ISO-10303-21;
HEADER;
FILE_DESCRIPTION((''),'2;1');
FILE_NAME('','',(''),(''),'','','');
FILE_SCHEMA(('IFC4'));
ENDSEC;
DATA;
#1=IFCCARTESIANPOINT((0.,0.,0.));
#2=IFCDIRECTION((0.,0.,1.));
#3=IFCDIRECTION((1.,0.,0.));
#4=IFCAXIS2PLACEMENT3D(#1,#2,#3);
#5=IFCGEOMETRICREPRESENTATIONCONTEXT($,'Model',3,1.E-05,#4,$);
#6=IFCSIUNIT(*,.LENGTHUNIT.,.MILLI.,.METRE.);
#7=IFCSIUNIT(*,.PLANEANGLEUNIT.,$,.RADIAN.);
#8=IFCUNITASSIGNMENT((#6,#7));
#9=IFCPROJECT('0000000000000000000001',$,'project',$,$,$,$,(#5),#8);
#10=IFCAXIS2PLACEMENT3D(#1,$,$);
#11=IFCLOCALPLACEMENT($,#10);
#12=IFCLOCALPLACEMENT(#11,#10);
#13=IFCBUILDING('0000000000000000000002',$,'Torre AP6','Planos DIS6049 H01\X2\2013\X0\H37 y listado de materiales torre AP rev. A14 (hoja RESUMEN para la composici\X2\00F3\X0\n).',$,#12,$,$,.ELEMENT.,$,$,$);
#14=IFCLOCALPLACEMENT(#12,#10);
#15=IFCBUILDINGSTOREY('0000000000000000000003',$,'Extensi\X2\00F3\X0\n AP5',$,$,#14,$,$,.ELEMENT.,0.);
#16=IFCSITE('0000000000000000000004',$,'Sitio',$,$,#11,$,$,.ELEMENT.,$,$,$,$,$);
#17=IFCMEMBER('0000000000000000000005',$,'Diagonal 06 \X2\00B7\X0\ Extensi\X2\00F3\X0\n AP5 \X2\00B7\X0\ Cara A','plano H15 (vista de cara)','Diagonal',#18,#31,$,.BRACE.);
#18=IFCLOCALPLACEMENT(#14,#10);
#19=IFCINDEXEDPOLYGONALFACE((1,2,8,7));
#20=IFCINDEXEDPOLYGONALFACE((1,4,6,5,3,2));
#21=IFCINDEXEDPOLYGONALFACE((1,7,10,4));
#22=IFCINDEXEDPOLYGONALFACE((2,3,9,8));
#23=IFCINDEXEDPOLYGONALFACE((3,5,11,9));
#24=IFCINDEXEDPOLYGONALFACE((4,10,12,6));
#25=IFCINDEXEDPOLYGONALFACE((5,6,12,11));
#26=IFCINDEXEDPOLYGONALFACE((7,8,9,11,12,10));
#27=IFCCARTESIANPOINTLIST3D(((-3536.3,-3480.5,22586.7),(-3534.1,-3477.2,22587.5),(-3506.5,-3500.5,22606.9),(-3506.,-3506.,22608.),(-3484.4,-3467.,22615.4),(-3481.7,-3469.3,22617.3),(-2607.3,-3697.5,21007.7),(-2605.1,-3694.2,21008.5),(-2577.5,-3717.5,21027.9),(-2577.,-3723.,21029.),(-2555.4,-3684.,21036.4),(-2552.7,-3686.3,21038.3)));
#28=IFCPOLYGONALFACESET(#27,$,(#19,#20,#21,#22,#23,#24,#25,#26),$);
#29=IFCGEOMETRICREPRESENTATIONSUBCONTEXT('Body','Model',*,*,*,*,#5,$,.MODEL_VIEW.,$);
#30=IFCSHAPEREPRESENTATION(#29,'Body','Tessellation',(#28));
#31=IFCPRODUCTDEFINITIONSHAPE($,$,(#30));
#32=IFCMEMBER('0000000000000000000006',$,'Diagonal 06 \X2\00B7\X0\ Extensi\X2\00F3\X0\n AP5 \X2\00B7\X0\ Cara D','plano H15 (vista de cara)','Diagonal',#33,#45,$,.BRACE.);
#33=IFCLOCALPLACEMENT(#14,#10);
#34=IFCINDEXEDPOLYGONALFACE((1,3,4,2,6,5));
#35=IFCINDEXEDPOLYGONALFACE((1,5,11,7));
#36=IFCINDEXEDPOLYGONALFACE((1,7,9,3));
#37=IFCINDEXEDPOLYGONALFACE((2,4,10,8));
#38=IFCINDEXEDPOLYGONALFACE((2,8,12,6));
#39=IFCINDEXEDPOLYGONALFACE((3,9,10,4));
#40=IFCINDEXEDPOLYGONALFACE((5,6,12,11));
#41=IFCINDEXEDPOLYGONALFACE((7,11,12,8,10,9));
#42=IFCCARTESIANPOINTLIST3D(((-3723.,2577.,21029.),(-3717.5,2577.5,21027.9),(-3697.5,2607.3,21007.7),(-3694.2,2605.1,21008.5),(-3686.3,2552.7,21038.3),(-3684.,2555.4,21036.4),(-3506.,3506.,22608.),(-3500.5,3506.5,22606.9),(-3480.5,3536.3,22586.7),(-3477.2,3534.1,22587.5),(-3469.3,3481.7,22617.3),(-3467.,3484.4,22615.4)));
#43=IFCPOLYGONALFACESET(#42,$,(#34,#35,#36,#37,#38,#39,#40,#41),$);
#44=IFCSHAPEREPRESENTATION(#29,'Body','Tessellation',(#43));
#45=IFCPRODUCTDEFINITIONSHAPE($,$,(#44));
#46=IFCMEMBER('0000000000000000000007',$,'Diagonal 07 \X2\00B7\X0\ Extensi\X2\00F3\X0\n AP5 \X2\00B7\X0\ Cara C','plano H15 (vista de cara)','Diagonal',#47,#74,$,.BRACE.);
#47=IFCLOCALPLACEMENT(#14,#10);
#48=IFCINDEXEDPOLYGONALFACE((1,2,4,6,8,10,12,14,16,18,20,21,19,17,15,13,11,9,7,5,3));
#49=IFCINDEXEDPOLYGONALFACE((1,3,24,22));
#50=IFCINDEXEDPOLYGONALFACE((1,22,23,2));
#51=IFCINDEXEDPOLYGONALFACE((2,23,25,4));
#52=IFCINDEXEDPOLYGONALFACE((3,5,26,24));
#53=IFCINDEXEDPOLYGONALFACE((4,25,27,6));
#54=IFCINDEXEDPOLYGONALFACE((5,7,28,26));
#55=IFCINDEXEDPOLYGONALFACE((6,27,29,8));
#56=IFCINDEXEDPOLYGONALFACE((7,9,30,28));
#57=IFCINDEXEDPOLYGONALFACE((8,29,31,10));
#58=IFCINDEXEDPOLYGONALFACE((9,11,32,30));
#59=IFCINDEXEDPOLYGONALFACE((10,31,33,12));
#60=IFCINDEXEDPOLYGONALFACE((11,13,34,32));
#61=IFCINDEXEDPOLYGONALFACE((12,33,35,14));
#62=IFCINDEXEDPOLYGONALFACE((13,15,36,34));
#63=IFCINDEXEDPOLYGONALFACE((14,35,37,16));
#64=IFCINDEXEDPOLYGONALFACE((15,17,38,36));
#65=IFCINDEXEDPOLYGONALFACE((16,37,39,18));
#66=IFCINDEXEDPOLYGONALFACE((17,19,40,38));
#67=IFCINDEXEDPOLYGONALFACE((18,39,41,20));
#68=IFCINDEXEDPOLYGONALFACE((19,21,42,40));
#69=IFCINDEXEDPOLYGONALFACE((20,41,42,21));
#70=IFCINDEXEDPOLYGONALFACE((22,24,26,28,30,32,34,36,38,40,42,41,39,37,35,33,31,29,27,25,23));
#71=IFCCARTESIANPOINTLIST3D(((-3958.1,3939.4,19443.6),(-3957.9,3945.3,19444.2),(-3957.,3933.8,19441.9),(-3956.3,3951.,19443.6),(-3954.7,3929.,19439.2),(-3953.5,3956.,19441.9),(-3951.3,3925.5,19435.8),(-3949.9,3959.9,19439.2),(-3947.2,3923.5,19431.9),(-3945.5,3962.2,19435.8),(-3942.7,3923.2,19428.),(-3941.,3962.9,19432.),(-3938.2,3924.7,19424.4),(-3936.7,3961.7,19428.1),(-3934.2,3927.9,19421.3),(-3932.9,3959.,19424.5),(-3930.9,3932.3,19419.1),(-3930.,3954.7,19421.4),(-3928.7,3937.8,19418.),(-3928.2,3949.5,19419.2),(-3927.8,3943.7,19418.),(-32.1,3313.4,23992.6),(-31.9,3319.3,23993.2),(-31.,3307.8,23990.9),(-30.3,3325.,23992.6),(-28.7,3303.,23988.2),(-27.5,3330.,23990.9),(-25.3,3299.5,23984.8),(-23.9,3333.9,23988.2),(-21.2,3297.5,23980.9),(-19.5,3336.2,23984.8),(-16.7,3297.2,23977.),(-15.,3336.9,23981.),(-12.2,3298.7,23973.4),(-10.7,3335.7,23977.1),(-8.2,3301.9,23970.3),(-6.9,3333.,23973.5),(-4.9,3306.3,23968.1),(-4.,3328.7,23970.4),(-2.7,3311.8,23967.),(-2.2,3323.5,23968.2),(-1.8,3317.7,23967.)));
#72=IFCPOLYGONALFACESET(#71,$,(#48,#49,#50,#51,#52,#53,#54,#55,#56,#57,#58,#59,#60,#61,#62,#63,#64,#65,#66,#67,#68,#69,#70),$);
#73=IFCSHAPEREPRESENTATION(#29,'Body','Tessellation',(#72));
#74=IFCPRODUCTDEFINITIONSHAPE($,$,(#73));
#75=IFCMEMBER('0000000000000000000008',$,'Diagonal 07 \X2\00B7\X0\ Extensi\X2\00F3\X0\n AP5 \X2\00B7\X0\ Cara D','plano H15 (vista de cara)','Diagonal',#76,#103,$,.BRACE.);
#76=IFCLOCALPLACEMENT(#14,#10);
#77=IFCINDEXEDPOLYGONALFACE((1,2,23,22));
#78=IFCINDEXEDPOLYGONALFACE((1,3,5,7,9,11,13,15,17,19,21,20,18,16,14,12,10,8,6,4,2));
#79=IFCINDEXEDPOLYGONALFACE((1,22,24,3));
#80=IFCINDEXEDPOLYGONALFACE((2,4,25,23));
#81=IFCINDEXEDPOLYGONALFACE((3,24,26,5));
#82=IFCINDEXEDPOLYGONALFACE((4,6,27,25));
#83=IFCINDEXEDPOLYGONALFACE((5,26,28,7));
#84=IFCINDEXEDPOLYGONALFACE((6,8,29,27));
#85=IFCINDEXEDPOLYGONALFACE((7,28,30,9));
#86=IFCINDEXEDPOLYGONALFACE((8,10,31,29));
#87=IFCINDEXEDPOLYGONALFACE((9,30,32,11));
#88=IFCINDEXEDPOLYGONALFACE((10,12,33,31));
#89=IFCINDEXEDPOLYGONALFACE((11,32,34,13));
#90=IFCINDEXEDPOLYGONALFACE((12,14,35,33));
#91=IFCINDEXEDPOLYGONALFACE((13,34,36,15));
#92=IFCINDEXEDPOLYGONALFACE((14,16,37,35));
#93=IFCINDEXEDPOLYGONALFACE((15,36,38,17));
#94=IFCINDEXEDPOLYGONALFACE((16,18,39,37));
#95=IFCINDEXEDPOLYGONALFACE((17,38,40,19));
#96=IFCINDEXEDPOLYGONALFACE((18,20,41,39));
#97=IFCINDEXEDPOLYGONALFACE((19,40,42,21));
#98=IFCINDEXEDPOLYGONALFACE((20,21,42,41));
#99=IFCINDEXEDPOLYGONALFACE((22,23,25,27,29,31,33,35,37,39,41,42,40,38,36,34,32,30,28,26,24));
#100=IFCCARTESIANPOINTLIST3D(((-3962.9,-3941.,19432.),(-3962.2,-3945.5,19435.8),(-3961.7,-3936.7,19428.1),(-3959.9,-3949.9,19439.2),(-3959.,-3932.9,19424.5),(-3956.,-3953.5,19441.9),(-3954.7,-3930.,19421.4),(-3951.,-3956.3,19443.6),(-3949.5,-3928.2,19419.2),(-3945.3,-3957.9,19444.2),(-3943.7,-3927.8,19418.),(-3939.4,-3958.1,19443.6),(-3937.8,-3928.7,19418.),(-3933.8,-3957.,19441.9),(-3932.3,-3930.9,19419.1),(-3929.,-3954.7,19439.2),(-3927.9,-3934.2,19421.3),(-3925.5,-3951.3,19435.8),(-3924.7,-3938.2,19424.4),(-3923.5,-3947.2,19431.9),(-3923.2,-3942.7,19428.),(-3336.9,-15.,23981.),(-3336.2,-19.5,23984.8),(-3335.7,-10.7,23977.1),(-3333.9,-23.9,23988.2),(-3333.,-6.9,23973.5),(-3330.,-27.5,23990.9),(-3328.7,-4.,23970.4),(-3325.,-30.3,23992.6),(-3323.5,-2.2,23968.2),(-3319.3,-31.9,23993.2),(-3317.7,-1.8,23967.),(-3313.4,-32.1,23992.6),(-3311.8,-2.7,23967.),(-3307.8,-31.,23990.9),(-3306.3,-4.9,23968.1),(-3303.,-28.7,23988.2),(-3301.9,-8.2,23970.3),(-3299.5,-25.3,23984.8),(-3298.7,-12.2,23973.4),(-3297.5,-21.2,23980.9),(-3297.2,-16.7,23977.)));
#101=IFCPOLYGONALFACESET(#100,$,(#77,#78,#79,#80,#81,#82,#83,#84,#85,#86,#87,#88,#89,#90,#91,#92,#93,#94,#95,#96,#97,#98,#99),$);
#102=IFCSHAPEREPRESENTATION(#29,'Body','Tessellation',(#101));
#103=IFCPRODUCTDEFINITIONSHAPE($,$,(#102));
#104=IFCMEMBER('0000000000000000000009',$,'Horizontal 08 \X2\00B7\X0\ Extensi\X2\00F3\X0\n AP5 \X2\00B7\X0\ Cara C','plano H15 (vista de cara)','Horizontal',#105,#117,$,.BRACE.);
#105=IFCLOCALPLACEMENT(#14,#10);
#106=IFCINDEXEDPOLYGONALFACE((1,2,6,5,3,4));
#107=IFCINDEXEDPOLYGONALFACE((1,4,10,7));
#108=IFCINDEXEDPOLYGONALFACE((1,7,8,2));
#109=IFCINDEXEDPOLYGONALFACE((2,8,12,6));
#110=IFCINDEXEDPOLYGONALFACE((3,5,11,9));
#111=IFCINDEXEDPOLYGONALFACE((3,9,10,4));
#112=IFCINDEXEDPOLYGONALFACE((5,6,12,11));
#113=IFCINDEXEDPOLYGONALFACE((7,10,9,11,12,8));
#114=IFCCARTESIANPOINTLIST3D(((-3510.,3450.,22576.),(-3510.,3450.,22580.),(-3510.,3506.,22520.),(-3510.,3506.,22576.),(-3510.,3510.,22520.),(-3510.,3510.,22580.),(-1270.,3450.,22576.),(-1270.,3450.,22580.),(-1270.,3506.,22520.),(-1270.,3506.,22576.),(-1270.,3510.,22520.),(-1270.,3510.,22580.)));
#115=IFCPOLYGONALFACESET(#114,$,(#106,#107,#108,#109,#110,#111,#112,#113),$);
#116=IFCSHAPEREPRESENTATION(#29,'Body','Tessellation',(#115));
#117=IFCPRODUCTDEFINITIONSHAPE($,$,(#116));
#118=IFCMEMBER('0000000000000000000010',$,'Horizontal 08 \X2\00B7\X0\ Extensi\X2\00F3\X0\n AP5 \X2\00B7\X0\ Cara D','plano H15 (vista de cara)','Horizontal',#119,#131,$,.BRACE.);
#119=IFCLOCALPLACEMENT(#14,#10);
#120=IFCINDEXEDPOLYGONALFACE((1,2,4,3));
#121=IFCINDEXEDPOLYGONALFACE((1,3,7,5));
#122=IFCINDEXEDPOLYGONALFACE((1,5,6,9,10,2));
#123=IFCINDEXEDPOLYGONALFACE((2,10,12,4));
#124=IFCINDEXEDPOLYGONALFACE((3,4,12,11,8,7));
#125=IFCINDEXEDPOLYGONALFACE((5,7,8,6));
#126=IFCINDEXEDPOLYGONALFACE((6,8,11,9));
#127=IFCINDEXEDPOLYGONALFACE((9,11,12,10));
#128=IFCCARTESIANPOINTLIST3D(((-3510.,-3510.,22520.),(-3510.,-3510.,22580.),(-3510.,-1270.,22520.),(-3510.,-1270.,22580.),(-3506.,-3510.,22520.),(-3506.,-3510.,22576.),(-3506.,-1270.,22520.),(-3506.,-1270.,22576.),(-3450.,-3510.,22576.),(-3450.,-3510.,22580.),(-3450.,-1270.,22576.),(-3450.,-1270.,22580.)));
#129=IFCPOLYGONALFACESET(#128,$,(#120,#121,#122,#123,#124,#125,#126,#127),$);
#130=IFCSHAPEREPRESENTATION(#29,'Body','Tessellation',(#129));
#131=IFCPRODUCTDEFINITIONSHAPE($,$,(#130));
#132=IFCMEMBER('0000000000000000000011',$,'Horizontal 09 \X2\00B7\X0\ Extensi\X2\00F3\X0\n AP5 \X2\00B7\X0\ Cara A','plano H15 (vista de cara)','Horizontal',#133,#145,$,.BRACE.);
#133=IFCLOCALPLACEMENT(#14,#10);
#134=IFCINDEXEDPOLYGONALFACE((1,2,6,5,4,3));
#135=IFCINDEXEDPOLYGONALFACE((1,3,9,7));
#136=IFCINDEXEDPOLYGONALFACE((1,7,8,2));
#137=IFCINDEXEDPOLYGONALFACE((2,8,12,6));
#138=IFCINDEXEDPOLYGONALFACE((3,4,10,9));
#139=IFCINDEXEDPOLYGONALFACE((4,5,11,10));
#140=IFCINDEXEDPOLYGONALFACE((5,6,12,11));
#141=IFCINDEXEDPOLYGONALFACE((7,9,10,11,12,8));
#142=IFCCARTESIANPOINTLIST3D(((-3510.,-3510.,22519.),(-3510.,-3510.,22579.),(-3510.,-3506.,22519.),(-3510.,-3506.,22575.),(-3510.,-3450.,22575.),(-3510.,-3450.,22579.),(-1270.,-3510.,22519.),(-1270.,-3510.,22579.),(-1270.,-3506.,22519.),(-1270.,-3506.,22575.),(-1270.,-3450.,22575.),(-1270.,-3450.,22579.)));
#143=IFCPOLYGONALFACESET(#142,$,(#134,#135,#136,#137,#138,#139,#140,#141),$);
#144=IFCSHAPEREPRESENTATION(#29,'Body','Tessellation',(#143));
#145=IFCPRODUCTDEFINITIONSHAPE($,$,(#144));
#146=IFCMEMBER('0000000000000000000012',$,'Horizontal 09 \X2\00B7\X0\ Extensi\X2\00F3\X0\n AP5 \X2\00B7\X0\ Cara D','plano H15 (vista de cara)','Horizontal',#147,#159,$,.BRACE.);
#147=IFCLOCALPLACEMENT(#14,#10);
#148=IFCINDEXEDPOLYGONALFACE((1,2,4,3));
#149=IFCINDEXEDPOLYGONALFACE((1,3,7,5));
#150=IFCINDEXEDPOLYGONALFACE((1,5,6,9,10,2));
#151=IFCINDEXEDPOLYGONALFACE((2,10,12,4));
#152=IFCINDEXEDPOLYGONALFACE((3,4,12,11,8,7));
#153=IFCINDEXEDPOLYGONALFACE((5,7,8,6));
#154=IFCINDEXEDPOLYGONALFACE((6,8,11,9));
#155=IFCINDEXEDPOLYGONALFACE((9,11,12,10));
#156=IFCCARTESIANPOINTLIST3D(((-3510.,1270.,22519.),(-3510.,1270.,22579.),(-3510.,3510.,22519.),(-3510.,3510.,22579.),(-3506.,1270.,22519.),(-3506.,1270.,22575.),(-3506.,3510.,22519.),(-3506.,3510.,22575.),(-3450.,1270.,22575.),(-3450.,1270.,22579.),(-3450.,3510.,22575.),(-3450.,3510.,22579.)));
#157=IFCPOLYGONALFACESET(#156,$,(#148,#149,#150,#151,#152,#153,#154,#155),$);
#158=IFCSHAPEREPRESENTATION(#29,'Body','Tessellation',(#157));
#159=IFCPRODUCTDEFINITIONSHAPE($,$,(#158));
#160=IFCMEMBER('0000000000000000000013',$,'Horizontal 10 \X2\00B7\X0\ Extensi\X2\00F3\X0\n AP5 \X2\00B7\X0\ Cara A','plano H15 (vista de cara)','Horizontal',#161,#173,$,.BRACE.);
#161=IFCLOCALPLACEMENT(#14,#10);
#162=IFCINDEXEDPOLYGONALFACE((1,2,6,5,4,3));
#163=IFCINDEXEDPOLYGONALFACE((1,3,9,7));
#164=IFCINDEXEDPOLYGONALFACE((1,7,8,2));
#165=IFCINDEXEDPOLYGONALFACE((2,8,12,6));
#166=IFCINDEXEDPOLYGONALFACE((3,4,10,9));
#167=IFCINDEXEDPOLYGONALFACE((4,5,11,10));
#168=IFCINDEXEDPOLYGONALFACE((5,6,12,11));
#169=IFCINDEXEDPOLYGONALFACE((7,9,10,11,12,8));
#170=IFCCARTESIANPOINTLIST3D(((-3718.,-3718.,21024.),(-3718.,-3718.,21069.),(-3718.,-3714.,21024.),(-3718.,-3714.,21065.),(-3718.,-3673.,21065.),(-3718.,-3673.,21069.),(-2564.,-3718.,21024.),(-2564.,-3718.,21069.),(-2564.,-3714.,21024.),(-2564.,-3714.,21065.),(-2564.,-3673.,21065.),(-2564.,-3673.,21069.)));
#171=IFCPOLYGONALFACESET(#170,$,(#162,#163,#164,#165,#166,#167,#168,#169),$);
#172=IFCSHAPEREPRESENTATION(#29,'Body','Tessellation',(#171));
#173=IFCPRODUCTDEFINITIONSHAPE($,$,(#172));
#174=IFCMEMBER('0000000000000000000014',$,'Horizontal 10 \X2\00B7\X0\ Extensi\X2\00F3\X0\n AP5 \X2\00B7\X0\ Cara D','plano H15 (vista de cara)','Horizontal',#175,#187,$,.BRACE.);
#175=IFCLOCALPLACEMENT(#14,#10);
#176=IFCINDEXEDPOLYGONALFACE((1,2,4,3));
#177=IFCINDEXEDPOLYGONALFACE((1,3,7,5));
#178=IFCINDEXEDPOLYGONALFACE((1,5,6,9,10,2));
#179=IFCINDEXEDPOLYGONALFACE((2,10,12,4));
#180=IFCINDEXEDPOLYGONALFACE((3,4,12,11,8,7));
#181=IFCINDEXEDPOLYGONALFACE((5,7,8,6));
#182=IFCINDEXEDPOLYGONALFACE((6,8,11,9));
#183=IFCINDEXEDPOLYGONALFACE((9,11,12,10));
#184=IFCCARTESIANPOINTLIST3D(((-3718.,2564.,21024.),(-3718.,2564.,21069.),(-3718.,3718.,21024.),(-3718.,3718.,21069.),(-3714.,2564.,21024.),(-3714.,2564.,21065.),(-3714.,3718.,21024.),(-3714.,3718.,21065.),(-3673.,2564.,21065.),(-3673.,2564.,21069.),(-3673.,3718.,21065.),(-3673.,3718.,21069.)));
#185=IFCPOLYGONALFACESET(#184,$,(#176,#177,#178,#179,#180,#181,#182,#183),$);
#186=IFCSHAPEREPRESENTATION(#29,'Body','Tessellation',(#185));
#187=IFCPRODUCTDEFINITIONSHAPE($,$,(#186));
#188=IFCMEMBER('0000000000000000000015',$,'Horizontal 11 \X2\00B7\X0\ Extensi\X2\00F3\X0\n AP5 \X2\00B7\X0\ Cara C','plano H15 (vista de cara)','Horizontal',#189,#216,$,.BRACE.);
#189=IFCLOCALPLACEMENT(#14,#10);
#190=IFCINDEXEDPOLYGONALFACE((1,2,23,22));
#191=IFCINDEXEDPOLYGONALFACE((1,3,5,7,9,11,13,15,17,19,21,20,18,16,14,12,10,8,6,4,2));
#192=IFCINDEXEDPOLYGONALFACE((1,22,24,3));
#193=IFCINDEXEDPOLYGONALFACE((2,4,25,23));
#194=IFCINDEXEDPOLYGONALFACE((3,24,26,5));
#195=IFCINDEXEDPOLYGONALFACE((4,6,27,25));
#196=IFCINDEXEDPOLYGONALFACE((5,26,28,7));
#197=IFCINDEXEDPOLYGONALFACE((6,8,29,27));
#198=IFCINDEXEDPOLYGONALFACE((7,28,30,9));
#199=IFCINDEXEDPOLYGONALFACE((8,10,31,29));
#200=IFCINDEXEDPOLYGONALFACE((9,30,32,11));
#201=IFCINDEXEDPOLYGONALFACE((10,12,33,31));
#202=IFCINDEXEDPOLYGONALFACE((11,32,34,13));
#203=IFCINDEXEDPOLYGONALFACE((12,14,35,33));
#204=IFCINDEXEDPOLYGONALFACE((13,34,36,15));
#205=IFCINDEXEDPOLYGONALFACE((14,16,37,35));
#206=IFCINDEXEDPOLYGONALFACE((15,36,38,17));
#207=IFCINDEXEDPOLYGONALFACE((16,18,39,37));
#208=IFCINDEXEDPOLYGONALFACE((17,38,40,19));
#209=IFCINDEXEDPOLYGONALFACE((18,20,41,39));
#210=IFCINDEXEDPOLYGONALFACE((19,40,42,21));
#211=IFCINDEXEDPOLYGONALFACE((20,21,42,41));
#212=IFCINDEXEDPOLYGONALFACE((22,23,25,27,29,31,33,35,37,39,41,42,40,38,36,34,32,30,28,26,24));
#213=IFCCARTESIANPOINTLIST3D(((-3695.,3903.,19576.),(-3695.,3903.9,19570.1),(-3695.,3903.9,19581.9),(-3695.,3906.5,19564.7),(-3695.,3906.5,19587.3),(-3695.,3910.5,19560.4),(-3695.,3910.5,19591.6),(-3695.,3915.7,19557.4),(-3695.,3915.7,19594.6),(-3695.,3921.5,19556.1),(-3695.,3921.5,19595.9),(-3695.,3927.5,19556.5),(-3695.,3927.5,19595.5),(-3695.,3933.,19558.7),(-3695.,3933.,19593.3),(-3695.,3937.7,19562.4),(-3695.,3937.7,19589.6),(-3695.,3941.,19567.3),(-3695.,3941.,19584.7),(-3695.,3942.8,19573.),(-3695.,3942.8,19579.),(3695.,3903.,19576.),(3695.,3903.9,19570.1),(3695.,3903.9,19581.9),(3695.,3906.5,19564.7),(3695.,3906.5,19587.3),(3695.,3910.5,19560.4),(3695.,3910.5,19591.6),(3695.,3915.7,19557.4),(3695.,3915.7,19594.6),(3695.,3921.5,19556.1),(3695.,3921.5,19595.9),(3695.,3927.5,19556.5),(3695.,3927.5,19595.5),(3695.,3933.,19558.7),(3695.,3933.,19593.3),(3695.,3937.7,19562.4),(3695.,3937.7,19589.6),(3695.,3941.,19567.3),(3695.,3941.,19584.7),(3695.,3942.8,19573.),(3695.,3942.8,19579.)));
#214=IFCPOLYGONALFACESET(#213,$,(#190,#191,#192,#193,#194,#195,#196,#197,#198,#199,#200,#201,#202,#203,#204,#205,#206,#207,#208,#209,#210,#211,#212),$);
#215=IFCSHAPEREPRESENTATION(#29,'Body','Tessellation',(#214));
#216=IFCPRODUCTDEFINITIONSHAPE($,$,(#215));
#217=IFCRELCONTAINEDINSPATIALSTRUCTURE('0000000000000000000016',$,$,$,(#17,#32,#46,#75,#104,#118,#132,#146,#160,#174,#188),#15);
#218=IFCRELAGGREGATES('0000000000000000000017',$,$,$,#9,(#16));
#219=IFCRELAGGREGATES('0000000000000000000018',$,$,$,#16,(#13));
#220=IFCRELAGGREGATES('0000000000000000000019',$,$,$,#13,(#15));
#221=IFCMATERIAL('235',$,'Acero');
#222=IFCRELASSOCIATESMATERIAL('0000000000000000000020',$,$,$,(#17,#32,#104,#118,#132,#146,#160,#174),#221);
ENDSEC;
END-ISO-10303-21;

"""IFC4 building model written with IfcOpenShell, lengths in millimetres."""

from ifc_helpers import new_model, si_unit, frame, frame_2d, origin, origin_with_axes, place, context, subcontext, project, spatial, circle, l_section, extrude, material, element, save


model = new_model("IFC4")

# Units and contexts
model_context = context("Model", 3, precision=1e-05, world=origin_with_axes())
body_context = subcontext(model_context, "Body", "Model", "MODEL_VIEW")
ifc_project = project(units=[si_unit("LENGTHUNIT", "METRE", prefix="MILLI"), si_unit("PLANEANGLEUNIT", "RADIAN")], contexts=[model_context])

# Site, building, storey
site_placement = place(None, origin())
site = spatial("IfcSite", under=ifc_project, at=site_placement, Name="Sitio", CompositionType="ELEMENT")
building_placement = place(site_placement, origin())
building = spatial("IfcBuilding", under=site, at=building_placement, Name="Torre AP6", Description="Planos DIS6049 H01–H37 y listado de materiales torre AP rev. A14 (hoja RESUMEN para la composición).", CompositionType="ELEMENT")
storey_placement = place(building_placement, origin())
storey = spatial("IfcBuildingStorey", under=building, at=storey_placement, Name="Extensión AP5", CompositionType="ELEMENT", Elevation=0.0)

# Members
ifc_material_1 = material(Name="235", Category="Acero")
for number, where, z_axis, x_axis, name in (
    (1, (-2577.0, -3723.0, 21029.0), (-0.503571, 0.117626, 0.855909), (0.540952, 0.815383, 0.20621), "Diagonal 06 · Extensión AP5 · Cara A"),
    (2, (-3723.0, 2577.0, 21029.0), (0.117626, 0.503571, 0.855909), (0.815383, -0.540952, 0.20621), "Diagonal 06 · Extensión AP5 · Cara D"),
):
    element("IfcMember", number, at=place(storey_placement, frame(where, z_axis=z_axis, x_axis=x_axis)), inside=storey, material=ifc_material_1, Name=name, Description="plano H15 (vista de cara)", ObjectType="Diagonal", PredefinedType="BRACE", context=body_context, shape_type="SweptSolid", body=[
        extrude(l_section(Depth=45.0, Width=45.0, Thickness=4.0, at=frame_2d((22.5, 22.5))), None, (0.0, 0.0, 1.0), 1844.8),
    ])
for number, where, z_axis, x_axis, name in (
    (3, (-3943.0, 3943.0, 19431.0), (0.649847, -0.103618, 0.752969), (0.237576, -0.913334, -0.330725), "Diagonal 07 · Extensión AP5 · Cara C"),
    (4, (-3943.0, -3943.0, 19431.0), (0.103618, 0.649847, 0.752969), (0.913334, 0.237576, -0.330725), "Diagonal 07 · Extensión AP5 · Cara D"),
):
    element("IfcMember", number, at=place(storey_placement, frame(where, z_axis=z_axis, x_axis=x_axis)), inside=storey, Name=name, Description="plano H15 (vista de cara)", ObjectType="Diagonal", PredefinedType="BRACE", context=body_context, shape_type="SweptSolid", body=[
        extrude(circle(Radius=20.0), None, (0.0, 0.0, 1.0), 6041.4),
    ])
for number, where, z_axis, x_axis, name in (
    (5, (-3510.0, 3510.0, 22580.0), (1.0, 0.0, 0.0), (0.0, -1.0, 0.0), "Horizontal 08 · Extensión AP5 · Cara C"),
    (6, (-3510.0, -3510.0, 22580.0), (0.0, 1.0, 0.0), (1.0, 0.0, 0.0), "Horizontal 08 · Extensión AP5 · Cara D"),
    (7, (-1270.0, -3510.0, 22579.0), (-1.0, 0.0, 0.0), (0.0, 1.0, 0.0), "Horizontal 09 · Extensión AP5 · Cara A"),
    (8, (-3510.0, 1270.0, 22579.0), (0.0, 1.0, 0.0), (1.0, 0.0, 0.0), "Horizontal 09 · Extensión AP5 · Cara D"),
):
    element("IfcMember", number, at=place(storey_placement, frame(where, z_axis=z_axis, x_axis=x_axis)), inside=storey, material=ifc_material_1, Name=name, Description="plano H15 (vista de cara)", ObjectType="Horizontal", PredefinedType="BRACE", context=body_context, shape_type="SweptSolid", body=[
        extrude(l_section(Depth=60.0, Width=60.0, Thickness=4.0, at=frame_2d((30.0, 30.0))), None, (0.0, 0.0, 1.0), 2240.0),
    ])
for number, where, z_axis, x_axis, name in (
    (9, (-2564.0, -3718.0, 21069.0), (-1.0, 0.0, 0.0), (0.0, 1.0, 0.0), "Horizontal 10 · Extensión AP5 · Cara A"),
    (10, (-3718.0, 2564.0, 21069.0), (0.0, 1.0, 0.0), (1.0, 0.0, 0.0), "Horizontal 10 · Extensión AP5 · Cara D"),
):
    element("IfcMember", number, at=place(storey_placement, frame(where, z_axis=z_axis, x_axis=x_axis)), inside=storey, material=ifc_material_1, Name=name, Description="plano H15 (vista de cara)", ObjectType="Horizontal", PredefinedType="BRACE", context=body_context, shape_type="SweptSolid", body=[
        extrude(l_section(Depth=45.0, Width=45.0, Thickness=4.0, at=frame_2d((22.5, 22.5))), None, (0.0, 0.0, 1.0), 1154.0),
    ])
for number, where, z_axis, x_axis, name in (
    (11, (-3695.0, 3923.0, 19576.0), (1.0, 0.0, 0.0), (0.0, -1.0, 0.0), "Horizontal 11 · Extensión AP5 · Cara C"),
):
    element("IfcMember", number, at=place(storey_placement, frame(where, z_axis=z_axis, x_axis=x_axis)), inside=storey, Name=name, Description="plano H15 (vista de cara)", ObjectType="Horizontal", PredefinedType="BRACE", context=body_context, shape_type="SweptSolid", body=[
        extrude(circle(Radius=20.0), None, (0.0, 0.0, 1.0), 7390.0),
    ])

save(model, "model.ifc")
